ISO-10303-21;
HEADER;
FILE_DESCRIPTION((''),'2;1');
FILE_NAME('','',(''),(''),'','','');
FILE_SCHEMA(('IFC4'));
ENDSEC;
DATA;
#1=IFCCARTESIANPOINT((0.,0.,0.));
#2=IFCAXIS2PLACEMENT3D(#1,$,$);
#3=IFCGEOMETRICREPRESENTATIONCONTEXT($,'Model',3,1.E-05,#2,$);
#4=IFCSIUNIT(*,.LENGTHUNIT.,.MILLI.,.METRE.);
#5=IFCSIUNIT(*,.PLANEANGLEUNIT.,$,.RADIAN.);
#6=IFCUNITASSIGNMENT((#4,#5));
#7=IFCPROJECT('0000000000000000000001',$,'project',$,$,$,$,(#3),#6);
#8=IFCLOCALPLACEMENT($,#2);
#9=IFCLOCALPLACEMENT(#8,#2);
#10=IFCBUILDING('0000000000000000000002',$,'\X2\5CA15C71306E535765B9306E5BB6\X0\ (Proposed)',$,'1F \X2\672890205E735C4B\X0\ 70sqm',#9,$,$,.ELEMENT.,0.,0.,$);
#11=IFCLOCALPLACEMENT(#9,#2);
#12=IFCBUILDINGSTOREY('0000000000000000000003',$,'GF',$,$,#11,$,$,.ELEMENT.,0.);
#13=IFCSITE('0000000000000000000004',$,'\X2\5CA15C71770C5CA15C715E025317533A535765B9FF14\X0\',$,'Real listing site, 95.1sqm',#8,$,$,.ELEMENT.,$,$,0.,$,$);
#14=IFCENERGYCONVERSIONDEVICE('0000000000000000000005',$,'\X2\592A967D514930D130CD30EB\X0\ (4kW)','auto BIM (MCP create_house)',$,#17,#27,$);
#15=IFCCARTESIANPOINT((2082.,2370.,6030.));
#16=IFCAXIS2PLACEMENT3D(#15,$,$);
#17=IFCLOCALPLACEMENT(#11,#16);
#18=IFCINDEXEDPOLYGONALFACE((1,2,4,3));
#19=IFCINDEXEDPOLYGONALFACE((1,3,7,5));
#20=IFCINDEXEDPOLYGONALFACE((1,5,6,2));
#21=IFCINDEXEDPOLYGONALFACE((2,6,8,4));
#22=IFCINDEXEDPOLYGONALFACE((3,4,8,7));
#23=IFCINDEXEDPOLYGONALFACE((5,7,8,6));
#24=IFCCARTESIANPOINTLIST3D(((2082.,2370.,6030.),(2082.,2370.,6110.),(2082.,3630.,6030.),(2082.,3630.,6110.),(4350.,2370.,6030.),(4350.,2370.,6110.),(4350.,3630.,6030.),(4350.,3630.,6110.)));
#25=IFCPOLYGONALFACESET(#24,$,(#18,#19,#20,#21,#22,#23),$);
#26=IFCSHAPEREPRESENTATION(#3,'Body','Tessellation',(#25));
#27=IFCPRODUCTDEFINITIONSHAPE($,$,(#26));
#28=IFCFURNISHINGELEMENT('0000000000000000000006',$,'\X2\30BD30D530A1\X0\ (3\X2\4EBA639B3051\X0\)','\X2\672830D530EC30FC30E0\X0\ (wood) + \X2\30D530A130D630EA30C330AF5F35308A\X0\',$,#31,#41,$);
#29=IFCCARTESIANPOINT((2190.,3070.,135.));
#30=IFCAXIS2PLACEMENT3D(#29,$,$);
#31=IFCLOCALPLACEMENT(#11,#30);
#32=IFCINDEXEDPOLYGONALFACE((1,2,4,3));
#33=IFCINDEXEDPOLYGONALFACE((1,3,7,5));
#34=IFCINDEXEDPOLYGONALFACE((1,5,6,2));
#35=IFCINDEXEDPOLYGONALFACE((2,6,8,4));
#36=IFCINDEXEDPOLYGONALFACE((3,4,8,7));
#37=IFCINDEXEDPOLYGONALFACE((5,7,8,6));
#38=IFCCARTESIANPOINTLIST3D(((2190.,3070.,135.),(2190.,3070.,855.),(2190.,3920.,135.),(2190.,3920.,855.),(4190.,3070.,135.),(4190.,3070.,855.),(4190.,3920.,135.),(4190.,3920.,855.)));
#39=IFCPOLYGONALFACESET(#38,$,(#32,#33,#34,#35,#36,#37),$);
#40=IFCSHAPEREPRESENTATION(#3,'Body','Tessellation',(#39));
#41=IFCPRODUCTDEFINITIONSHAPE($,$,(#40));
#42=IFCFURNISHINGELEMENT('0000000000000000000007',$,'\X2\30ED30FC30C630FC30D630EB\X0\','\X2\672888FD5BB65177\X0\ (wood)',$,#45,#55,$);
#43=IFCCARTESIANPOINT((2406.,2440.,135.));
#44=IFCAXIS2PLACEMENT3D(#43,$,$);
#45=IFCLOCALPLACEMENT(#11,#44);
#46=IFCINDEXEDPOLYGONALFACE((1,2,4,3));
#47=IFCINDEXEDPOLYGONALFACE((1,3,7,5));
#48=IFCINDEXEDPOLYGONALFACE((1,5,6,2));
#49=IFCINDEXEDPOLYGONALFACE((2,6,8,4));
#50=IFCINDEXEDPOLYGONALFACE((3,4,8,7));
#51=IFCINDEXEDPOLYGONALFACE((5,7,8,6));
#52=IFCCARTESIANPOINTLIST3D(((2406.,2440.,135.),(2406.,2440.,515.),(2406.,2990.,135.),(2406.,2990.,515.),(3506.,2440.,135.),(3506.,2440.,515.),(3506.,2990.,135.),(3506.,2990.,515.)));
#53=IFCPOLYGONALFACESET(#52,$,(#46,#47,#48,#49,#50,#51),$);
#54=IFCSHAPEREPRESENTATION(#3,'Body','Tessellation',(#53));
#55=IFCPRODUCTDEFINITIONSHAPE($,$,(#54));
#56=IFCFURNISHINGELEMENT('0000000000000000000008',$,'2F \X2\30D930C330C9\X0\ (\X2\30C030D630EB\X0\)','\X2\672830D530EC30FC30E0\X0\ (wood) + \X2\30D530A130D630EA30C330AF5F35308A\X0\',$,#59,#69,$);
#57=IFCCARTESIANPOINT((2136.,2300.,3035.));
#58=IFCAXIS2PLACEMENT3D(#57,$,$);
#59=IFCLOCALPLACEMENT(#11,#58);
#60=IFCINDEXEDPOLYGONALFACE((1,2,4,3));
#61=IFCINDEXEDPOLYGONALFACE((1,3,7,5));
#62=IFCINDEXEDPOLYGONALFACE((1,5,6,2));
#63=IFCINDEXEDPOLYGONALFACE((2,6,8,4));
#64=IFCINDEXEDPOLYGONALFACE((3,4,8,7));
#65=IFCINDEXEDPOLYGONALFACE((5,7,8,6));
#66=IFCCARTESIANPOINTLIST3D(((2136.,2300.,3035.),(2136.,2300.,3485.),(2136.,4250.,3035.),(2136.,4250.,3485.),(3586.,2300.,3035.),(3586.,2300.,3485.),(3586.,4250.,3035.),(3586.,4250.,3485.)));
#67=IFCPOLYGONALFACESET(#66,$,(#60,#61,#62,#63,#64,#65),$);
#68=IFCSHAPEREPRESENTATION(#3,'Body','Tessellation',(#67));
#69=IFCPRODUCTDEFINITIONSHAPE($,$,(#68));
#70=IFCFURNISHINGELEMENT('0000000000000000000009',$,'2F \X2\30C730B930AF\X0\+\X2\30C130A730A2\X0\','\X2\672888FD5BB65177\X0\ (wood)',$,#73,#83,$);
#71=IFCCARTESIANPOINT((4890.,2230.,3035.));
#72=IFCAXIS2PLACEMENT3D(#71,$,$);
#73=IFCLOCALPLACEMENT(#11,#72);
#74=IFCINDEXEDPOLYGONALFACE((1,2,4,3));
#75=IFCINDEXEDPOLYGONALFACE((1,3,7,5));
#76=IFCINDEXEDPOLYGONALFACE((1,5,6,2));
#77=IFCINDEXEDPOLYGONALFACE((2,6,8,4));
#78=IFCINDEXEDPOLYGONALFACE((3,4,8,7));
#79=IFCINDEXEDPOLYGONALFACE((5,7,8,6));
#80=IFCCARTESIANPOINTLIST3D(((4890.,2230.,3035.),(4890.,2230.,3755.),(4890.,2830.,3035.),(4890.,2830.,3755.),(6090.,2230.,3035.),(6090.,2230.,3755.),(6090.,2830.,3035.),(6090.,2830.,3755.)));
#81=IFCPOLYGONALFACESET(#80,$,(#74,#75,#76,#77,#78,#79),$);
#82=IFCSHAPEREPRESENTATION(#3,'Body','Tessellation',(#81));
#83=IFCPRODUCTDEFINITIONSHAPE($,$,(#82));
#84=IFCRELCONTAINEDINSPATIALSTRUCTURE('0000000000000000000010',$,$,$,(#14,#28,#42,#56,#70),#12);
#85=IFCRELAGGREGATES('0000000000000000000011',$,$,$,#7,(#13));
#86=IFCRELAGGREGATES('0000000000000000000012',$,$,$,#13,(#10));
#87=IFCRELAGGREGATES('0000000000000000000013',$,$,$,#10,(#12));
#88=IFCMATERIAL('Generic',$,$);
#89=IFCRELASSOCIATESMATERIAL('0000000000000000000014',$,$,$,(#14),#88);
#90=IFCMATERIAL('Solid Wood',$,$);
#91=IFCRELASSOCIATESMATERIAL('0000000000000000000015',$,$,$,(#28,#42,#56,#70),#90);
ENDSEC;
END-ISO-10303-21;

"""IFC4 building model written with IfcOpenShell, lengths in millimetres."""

from ifc_helpers import new_model, si_unit, frame, frame_2d, origin, place, context, project, spatial, rectangle, extrude, material, element, save


model = new_model("IFC4")

# Units and contexts
model_context = context("Model", 3, precision=1e-05, world=origin())
ifc_project = project(units=[si_unit("LENGTHUNIT", "METRE", prefix="MILLI"), si_unit("PLANEANGLEUNIT", "RADIAN")], contexts=[model_context])

# Site, building, storey
site_placement = place(None, origin())
site = spatial("IfcSite", under=ifc_project, at=site_placement, Name="岡山県岡山市北区南方４", ObjectType="Real listing site, 95.1sqm", CompositionType="ELEMENT", RefElevation=0.0)
building_placement = place(site_placement, origin())
building = spatial("IfcBuilding", under=site, at=building_placement, Name="岡山の南方の家 (Proposed)", ObjectType="1F 木造平屋 70sqm", CompositionType="ELEMENT", ElevationOfRefHeight=0.0, ElevationOfTerrain=0.0)
storey_placement = place(building_placement, origin())
storey = spatial("IfcBuildingStorey", under=building, at=storey_placement, Name="GF", CompositionType="ELEMENT", Elevation=0.0)

# Shared definitions
ifc_material_1 = material(Name="Solid Wood")

# Shared definitions
ifc_material_2 = material(Name="Generic")

# Energy conversion device
energy_conversion_device_placement = place(storey_placement, frame((2082.0, 2370.0, 6030.0)))
element("IfcEnergyConversionDevice", 1, at=energy_conversion_device_placement, inside=storey, material=ifc_material_2, Name="太陽光パネル (4kW)", Description="auto BIM (MCP create_house)", context=model_context, shape_type="SweptSolid", body=[
    extrude(rectangle(XDim=2268.0, YDim=1260.0, at=frame_2d((1134.0, 630.0))), frame((2082.0, 2370.0, 6030.0)), (0.0, 0.0, 1.0), 80.0),
])

# Furnishing elements
furnishing_1_placement = place(storey_placement, frame((2190.0, 3070.0, 135.0)))
element("IfcFurnishingElement", 2, at=furnishing_1_placement, inside=storey, material=ifc_material_1, Name="ソファ (3人掛け)", Description="木フレーム (wood) + ファブリック張り", context=model_context, shape_type="SweptSolid", body=[
    extrude(rectangle(XDim=2000.0, YDim=850.0, at=frame_2d((1000.0, 425.0))), frame((2190.0, 3070.0, 135.0)), (0.0, 0.0, 1.0), 720.0),
])
furnishing_2_placement = place(storey_placement, frame((2406.0, 2440.0, 135.0)))
element("IfcFurnishingElement", 3, at=furnishing_2_placement, inside=storey, material=ifc_material_1, Name="ローテーブル", Description="木製家具 (wood)", context=model_context, shape_type="SweptSolid", body=[
    extrude(rectangle(XDim=1100.0, YDim=550.0, at=frame_2d((550.0, 275.0))), frame((2406.0, 2440.0, 135.0)), (0.0, 0.0, 1.0), 380.0),
])
furnishing_3_placement = place(storey_placement, frame((2136.0, 2300.0, 3035.0)))
element("IfcFurnishingElement", 4, at=furnishing_3_placement, inside=storey, material=ifc_material_1, Name="2F ベッド (ダブル)", Description="木フレーム (wood) + ファブリック張り", context=model_context, shape_type="SweptSolid", body=[
    extrude(rectangle(XDim=1450.0, YDim=1950.0, at=frame_2d((725.0, 975.0))), frame((2136.0, 2300.0, 3035.0)), (0.0, 0.0, 1.0), 450.0),
])
furnishing_4_placement = place(storey_placement, frame((4890.0, 2230.0, 3035.0)))
element("IfcFurnishingElement", 5, at=furnishing_4_placement, inside=storey, material=ifc_material_1, Name="2F デスク+チェア", Description="木製家具 (wood)", context=model_context, shape_type="SweptSolid", body=[
    extrude(rectangle(XDim=1200.0, YDim=600.0, at=frame_2d((600.0, 300.0))), frame((4890.0, 2230.0, 3035.0)), (0.0, 0.0, 1.0), 720.0),
])

save(model, "model.ifc")
